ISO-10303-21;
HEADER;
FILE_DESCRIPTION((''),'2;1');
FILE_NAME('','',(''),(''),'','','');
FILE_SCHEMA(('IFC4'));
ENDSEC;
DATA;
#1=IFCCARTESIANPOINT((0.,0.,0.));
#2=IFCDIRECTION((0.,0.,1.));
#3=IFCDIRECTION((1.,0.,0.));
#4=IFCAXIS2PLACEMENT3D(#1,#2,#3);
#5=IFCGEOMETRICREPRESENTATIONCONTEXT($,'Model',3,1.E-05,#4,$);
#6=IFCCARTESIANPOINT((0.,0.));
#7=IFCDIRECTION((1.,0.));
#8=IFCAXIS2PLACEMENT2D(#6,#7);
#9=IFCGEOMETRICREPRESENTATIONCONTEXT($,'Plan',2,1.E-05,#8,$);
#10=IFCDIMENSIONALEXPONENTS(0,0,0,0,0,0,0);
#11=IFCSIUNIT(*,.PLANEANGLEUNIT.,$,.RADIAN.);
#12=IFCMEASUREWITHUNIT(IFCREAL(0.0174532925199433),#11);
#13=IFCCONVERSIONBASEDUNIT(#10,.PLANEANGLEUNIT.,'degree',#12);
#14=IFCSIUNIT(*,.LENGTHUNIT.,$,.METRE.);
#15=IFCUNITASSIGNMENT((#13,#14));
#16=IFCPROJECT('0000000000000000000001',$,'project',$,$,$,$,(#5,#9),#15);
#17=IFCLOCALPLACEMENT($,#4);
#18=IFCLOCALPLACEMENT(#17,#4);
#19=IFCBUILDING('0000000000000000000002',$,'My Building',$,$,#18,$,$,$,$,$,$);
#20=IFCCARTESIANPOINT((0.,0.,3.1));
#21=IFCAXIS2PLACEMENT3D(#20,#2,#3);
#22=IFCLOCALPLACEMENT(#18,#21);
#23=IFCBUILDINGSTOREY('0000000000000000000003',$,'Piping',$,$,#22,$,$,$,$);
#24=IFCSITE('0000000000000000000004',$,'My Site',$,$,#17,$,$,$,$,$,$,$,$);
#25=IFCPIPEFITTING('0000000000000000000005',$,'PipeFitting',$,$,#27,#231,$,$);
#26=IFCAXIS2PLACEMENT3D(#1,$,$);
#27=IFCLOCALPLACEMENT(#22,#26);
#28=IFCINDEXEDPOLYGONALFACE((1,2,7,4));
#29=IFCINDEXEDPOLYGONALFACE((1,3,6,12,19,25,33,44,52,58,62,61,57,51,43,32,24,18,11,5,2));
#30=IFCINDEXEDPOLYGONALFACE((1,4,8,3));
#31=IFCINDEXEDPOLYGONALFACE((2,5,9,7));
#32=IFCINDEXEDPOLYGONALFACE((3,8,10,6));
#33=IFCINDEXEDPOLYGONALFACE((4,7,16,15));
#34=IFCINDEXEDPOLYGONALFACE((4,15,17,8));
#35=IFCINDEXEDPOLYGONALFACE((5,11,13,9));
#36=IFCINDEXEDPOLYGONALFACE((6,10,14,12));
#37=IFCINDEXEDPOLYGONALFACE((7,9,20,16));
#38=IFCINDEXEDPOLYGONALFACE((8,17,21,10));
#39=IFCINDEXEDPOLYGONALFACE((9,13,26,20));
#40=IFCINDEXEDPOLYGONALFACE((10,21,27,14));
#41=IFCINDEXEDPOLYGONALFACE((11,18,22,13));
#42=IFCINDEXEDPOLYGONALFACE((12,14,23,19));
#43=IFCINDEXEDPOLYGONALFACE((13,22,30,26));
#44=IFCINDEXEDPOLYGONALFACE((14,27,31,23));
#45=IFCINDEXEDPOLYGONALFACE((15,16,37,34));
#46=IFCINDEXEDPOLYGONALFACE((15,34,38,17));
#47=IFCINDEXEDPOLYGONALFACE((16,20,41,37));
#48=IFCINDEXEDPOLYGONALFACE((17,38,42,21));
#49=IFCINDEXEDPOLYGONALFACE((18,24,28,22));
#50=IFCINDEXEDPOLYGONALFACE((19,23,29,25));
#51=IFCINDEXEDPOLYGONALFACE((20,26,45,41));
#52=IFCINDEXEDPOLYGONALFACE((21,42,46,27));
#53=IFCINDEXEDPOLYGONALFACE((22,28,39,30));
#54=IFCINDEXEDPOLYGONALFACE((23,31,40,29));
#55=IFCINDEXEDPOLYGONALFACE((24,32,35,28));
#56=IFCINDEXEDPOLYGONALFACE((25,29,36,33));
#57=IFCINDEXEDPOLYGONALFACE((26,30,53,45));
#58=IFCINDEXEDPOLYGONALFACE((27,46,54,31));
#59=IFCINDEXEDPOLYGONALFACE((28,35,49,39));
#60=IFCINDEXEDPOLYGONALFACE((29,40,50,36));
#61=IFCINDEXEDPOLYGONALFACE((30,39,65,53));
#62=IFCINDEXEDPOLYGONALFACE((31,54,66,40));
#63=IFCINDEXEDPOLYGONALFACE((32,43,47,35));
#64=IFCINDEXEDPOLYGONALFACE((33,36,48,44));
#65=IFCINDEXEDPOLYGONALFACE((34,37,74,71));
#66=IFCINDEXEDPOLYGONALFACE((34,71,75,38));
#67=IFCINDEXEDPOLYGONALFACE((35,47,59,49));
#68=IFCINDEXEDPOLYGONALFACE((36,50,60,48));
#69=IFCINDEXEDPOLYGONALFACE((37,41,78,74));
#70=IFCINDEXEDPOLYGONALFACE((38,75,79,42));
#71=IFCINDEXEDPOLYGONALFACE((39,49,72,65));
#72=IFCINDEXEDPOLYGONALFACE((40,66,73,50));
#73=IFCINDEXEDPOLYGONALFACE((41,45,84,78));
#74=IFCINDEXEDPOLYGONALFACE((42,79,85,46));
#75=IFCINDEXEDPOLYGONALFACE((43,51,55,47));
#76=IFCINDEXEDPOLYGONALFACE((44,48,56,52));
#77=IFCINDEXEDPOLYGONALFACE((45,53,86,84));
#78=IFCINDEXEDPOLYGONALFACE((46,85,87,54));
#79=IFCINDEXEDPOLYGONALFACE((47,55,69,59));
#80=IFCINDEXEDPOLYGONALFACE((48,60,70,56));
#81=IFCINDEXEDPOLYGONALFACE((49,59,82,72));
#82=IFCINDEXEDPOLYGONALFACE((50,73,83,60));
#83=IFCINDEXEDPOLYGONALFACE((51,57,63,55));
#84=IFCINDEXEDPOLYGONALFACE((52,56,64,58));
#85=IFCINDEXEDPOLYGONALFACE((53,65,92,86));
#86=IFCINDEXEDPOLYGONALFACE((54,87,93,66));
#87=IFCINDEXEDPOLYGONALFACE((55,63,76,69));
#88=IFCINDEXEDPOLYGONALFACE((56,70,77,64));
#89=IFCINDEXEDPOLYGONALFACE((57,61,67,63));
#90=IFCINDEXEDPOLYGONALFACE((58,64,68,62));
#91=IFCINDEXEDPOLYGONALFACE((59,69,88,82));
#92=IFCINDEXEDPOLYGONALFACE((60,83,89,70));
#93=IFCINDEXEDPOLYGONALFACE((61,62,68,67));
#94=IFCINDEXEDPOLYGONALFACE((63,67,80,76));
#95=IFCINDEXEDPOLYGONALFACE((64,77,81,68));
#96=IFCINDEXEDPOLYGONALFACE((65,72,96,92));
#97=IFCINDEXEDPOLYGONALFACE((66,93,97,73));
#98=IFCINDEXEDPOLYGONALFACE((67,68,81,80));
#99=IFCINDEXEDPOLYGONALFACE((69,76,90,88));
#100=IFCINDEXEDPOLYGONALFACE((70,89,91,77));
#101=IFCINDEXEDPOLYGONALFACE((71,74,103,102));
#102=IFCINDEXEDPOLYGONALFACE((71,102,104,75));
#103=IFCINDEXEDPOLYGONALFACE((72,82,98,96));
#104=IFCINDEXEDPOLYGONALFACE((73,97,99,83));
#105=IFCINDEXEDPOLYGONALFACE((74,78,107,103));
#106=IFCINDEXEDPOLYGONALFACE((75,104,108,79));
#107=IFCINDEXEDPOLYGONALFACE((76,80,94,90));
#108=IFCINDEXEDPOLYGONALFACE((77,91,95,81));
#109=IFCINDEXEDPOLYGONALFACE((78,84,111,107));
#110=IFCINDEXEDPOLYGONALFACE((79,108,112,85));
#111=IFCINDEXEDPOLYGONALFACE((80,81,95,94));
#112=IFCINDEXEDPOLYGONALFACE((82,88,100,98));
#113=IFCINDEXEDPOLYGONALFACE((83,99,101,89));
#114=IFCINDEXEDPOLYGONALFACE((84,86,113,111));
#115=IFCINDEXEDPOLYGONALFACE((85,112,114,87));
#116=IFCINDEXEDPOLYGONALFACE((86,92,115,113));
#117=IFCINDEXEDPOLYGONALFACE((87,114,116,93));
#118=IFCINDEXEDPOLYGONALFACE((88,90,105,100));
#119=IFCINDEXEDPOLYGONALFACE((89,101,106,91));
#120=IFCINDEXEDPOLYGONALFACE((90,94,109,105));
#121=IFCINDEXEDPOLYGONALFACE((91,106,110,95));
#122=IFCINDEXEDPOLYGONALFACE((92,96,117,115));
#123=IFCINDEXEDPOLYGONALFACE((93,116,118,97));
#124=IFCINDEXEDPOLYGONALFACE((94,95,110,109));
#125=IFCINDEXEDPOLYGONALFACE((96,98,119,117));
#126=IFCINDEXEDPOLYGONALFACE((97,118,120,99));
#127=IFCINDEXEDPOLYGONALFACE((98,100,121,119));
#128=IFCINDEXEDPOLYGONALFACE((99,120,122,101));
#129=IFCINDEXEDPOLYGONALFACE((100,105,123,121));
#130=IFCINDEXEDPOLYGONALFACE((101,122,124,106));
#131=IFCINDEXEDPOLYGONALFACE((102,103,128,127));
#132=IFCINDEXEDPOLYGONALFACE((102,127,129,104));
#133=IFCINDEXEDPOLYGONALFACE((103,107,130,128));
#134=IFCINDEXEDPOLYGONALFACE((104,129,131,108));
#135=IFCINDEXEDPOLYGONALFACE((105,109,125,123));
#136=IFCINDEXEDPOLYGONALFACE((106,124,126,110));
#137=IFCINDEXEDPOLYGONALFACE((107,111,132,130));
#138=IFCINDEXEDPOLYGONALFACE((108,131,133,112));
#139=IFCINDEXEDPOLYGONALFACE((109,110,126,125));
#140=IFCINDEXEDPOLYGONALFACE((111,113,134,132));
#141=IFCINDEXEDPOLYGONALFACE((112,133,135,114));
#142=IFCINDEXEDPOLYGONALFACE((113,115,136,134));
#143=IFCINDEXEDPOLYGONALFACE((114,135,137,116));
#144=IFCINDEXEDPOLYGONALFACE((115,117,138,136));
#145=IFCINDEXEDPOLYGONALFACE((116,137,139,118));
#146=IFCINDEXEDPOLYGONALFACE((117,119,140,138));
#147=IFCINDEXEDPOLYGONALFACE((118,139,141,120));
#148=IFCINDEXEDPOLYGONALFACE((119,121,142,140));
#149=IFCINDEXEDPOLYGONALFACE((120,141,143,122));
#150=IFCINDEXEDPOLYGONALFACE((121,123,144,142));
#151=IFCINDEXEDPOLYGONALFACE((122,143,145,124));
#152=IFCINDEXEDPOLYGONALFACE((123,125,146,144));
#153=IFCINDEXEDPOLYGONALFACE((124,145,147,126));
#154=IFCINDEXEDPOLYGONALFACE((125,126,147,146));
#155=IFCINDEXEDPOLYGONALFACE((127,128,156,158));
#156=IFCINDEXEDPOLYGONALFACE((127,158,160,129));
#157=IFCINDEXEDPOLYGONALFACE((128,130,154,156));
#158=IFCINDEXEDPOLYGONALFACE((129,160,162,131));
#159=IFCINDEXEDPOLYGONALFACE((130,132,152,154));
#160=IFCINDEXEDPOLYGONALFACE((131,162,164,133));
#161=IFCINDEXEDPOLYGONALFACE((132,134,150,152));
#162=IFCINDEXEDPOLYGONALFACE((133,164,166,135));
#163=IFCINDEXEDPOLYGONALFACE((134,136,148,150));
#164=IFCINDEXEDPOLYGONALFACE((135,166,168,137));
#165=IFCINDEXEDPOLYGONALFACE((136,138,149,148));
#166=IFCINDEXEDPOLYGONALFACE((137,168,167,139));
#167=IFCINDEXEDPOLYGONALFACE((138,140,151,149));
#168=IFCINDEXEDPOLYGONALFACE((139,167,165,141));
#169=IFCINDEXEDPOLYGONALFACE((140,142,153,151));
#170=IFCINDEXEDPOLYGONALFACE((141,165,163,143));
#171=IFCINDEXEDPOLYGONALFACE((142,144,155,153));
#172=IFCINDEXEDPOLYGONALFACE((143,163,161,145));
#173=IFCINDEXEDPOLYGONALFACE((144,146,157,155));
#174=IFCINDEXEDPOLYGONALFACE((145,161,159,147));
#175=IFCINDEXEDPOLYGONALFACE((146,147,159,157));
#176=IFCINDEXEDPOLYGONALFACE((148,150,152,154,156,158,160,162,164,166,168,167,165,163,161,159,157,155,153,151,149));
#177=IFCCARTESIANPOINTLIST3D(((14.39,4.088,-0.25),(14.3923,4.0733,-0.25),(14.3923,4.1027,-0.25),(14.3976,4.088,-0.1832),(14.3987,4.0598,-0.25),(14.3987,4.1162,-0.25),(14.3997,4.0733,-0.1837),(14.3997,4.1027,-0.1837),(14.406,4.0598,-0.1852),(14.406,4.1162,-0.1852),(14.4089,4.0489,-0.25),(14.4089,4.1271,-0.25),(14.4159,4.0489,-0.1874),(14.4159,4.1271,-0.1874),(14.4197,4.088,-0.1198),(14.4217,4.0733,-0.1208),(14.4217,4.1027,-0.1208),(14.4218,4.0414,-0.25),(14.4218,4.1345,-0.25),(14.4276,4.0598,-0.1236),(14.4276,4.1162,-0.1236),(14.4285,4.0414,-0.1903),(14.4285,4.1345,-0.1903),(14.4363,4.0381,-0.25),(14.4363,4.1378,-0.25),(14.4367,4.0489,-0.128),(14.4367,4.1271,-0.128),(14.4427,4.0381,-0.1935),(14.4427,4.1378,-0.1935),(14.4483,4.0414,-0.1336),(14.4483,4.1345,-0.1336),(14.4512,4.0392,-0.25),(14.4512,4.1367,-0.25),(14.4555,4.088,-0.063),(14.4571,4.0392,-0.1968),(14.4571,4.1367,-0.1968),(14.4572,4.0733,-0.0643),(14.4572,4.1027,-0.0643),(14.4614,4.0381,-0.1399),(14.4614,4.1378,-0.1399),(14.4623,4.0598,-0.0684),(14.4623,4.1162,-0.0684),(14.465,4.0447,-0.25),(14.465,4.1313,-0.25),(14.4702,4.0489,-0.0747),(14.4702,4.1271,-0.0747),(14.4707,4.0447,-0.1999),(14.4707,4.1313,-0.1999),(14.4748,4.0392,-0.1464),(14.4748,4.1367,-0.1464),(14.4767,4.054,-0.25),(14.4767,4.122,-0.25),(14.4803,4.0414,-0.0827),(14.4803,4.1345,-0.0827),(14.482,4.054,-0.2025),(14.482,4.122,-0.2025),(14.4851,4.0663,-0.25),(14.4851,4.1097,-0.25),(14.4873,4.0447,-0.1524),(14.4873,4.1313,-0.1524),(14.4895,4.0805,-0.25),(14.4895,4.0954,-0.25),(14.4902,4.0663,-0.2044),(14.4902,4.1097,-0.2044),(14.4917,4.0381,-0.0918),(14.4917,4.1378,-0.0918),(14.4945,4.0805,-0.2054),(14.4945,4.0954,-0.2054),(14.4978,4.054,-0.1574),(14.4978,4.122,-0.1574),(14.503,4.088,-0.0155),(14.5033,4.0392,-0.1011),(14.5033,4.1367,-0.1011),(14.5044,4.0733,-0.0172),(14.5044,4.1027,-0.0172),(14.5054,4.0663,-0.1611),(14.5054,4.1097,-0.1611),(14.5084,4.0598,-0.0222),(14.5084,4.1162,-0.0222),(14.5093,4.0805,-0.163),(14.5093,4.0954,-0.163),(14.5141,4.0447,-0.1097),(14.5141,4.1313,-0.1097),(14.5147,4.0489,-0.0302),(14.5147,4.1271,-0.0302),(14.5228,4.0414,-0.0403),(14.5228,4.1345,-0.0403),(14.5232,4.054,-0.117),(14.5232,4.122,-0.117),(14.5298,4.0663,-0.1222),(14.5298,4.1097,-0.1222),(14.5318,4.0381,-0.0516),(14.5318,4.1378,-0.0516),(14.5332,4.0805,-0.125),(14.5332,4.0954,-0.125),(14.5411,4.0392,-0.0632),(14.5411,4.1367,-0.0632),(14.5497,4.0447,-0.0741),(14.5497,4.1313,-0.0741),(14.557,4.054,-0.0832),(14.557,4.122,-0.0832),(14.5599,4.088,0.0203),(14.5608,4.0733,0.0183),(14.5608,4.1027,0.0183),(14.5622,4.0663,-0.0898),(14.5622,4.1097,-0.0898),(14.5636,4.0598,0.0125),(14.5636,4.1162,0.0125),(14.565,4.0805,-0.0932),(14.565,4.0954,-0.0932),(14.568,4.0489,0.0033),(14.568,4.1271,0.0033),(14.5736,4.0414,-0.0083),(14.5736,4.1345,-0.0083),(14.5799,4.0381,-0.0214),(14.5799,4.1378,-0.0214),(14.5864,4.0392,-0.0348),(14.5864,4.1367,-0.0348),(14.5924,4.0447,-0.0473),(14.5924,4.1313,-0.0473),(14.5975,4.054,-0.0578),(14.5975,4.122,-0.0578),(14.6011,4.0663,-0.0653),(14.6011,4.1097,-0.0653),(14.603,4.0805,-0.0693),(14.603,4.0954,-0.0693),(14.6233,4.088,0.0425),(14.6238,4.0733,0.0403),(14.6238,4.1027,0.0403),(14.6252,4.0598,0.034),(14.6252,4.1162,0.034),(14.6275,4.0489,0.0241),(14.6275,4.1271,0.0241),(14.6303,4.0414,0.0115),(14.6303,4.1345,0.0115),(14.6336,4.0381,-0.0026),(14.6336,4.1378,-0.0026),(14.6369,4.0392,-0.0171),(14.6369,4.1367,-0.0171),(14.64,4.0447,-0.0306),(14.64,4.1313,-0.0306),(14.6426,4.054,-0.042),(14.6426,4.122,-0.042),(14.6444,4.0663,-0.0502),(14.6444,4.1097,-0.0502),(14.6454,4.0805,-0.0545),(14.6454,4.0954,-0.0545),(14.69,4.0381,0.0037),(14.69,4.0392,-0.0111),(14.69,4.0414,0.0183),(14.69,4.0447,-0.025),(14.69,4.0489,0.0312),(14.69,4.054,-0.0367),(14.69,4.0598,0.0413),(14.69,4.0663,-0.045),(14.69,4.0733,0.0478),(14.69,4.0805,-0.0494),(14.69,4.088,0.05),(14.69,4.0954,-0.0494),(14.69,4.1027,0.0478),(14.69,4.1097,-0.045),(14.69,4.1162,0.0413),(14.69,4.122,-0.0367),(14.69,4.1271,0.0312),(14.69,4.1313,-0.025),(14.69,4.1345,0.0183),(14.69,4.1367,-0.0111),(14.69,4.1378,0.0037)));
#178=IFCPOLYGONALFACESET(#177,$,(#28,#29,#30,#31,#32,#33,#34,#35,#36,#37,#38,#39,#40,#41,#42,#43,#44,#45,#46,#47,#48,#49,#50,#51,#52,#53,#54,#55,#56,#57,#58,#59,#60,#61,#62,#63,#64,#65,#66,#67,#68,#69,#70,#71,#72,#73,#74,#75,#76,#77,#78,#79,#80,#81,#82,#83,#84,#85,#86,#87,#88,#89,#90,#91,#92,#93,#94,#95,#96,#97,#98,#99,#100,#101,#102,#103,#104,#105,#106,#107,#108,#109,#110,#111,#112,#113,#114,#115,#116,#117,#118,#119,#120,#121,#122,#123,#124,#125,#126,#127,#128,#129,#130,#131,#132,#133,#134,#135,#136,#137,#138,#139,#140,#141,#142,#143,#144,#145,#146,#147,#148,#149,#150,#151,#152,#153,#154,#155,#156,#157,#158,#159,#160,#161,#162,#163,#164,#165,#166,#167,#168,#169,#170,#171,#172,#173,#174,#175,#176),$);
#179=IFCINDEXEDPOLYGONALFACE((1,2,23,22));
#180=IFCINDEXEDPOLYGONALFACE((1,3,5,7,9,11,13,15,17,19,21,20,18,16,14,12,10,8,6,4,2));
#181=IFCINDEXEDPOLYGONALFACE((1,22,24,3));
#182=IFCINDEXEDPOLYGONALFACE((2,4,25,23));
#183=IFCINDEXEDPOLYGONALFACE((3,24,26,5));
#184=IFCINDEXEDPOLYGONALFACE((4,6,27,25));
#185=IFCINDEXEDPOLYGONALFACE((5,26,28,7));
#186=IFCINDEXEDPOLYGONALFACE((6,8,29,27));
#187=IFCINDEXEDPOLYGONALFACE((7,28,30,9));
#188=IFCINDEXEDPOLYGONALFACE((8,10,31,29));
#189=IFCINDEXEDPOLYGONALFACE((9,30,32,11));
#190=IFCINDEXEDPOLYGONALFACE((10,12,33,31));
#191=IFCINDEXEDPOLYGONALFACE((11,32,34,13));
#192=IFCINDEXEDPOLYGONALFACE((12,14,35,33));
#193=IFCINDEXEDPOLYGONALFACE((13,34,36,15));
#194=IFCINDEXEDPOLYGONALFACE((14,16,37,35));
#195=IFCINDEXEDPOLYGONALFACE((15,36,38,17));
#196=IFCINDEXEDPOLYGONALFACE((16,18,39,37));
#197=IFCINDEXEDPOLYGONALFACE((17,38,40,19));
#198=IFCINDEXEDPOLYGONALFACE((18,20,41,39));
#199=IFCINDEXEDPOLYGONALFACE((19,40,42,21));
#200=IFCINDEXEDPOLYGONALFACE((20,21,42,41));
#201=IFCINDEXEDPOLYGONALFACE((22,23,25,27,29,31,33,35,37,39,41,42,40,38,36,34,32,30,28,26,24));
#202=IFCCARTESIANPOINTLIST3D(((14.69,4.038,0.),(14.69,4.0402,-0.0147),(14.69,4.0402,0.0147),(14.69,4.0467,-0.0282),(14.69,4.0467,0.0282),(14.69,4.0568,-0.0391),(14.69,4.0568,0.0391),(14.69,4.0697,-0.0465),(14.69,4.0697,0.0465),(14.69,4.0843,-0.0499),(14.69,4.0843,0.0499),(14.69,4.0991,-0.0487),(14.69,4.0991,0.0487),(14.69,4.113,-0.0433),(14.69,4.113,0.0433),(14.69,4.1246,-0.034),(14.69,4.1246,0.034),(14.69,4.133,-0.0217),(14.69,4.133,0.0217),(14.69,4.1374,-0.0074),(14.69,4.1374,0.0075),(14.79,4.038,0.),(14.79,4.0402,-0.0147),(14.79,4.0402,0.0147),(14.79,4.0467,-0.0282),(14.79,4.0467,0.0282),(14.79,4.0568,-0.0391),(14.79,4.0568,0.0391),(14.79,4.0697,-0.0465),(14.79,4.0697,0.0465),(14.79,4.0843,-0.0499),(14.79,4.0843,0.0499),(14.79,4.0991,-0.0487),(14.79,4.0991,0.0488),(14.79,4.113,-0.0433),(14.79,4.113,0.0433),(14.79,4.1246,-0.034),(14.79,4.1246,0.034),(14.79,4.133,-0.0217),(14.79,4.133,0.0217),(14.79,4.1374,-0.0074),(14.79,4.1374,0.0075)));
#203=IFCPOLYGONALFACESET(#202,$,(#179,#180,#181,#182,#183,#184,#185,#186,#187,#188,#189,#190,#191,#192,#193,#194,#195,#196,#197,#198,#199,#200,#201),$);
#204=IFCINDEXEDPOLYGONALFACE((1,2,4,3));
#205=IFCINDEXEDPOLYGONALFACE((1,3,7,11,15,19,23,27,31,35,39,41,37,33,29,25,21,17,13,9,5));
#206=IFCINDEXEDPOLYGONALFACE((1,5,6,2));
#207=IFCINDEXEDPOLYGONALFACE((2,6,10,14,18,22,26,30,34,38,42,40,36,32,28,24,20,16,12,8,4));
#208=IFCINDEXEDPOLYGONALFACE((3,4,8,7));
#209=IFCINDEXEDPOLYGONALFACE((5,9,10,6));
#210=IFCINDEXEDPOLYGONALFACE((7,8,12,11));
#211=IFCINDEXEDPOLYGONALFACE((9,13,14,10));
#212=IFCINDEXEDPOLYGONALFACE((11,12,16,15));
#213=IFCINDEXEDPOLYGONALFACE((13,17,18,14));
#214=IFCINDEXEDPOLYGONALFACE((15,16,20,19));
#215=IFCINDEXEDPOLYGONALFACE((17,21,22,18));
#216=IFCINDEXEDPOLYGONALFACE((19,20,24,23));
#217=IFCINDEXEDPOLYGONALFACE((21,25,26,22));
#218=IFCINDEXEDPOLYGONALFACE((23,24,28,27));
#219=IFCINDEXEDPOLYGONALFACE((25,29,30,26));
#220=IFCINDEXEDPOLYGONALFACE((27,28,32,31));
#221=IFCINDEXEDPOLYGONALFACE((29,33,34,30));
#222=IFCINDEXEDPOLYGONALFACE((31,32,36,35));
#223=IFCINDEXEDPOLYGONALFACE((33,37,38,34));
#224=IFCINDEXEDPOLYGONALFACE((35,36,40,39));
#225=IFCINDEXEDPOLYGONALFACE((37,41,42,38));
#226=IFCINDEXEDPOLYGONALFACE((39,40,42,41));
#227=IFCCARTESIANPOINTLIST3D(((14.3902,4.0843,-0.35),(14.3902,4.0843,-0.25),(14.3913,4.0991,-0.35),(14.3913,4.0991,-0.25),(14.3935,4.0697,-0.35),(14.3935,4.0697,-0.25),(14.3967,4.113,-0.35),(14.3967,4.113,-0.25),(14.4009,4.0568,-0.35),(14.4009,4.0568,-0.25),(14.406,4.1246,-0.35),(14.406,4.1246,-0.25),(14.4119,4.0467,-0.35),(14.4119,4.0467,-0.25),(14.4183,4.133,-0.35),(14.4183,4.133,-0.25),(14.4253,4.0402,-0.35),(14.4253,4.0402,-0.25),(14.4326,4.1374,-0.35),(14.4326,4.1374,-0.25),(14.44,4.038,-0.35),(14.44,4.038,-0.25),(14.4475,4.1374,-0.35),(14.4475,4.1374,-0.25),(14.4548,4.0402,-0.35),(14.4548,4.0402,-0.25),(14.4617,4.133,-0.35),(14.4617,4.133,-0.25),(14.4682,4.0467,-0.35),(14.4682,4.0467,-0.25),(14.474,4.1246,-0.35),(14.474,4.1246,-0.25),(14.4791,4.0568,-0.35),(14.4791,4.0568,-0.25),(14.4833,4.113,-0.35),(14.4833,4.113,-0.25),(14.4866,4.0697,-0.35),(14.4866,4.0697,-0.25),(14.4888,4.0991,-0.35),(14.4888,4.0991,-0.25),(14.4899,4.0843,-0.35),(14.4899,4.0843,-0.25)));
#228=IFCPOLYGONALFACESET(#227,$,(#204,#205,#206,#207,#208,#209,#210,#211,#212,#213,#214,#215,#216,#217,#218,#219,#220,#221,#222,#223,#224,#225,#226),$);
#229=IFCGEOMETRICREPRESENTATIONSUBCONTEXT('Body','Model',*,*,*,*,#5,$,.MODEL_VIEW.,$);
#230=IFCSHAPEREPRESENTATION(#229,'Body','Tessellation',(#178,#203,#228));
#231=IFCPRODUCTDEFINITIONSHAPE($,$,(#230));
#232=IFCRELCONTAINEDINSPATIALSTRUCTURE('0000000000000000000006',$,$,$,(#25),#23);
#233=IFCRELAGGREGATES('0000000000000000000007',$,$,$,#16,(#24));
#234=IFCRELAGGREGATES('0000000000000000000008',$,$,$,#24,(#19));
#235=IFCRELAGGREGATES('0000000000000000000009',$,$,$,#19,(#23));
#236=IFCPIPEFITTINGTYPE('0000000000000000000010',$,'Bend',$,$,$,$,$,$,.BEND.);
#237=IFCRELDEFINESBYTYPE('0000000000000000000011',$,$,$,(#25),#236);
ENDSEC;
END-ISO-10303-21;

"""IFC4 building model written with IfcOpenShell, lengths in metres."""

from ifc_helpers import new_model, entity, si_unit, converted_unit, frame, origin_with_axes, origin_2d_with_axis, place, context, subcontext, project, spatial, circle, extrude, source, transform, mapped, type_object, type_shapes, element, save


model = new_model("IFC4")

# Units and contexts
model_context = context("Model", 3, precision=1e-05, world=origin_with_axes())
plan_context = context("Plan", 2, precision=1e-05, world=origin_2d_with_axis())
body_context = subcontext(model_context, "Body", "Model", "MODEL_VIEW")
ifc_project = project(units=[converted_unit("PLANEANGLEUNIT", "degree", entity("IfcReal", 0.0174532925199433), si_unit("PLANEANGLEUNIT", "RADIAN"), dimensions=[0, 0, 0, 0, 0, 0, 0]), si_unit("LENGTHUNIT", "METRE")], contexts=[model_context, plan_context])

# Site, building, storey
site_placement = place(None, origin_with_axes())
site = spatial("IfcSite", under=ifc_project, at=site_placement, Name="My Site")
building_placement = place(site_placement, origin_with_axes())
building = spatial("IfcBuilding", under=site, at=building_placement, Name="My Building")
storey_placement = place(building_placement, frame((0.0, 0.0, 3.1), z_axis=(0.0, 0.0, 1.0), x_axis=(1.0, 0.0, 0.0)))
storey = spatial("IfcBuildingStorey", under=building, at=storey_placement, Name="Piping")

# Pipe fitting
pipe_fitting_type_1 = type_object("IfcPipeFittingType", Name="Bend", PredefinedType="BEND")
shared_shape_1 = source(origin_with_axes(), body_context, "Body", "SolidModel", [
    entity("IfcSweptDiskSolid", entity("IfcIndexedPolyCurve", entity("IfcCartesianPointList3D", [[0.0, 0.0, 0.1], [0.0, -0.0732, 0.2768], [0.0, -0.25, 0.35]]), [entity("IfcArcIndex", [1, 2, 3])]), 0.05),
    extrude(circle(Radius=0.05), origin_with_axes(), (0.0, 0.0, 1.0), 0.1),
    extrude(circle(Radius=0.05), frame((0.0, -0.25, 0.35), z_axis=(0.0, -1.0, 0.000022), x_axis=(1.0, 0.0, 0.0)), (0.0, 0.0, 1.0), 0.1),
])
type_shapes(pipe_fitting_type_1, [shared_shape_1])
for number, where, z_axis, x_axis, name in (
    (1, (14.79, 4.088, 0.0), (-1.0, 0.0, -0.000022), (0.0, -1.0, 0.0), "PipeFitting"),
):
    element("IfcPipeFitting", number, at=place(storey_placement, frame(where, z_axis=z_axis, x_axis=x_axis)), inside=storey, type_object=pipe_fitting_type_1, Name=name, context=body_context, shape_type="MappedRepresentation", body=[
        mapped(shared_shape_1, transform((0.0, 0.0, 0.0), x_axis=(1.0, 0.0, 0.0), y_axis=(0.0, 1.0, 0.0), z_axis=(0.0, 0.0, 1.0), scale=1.0)),
    ])

save(model, "model.ifc")
